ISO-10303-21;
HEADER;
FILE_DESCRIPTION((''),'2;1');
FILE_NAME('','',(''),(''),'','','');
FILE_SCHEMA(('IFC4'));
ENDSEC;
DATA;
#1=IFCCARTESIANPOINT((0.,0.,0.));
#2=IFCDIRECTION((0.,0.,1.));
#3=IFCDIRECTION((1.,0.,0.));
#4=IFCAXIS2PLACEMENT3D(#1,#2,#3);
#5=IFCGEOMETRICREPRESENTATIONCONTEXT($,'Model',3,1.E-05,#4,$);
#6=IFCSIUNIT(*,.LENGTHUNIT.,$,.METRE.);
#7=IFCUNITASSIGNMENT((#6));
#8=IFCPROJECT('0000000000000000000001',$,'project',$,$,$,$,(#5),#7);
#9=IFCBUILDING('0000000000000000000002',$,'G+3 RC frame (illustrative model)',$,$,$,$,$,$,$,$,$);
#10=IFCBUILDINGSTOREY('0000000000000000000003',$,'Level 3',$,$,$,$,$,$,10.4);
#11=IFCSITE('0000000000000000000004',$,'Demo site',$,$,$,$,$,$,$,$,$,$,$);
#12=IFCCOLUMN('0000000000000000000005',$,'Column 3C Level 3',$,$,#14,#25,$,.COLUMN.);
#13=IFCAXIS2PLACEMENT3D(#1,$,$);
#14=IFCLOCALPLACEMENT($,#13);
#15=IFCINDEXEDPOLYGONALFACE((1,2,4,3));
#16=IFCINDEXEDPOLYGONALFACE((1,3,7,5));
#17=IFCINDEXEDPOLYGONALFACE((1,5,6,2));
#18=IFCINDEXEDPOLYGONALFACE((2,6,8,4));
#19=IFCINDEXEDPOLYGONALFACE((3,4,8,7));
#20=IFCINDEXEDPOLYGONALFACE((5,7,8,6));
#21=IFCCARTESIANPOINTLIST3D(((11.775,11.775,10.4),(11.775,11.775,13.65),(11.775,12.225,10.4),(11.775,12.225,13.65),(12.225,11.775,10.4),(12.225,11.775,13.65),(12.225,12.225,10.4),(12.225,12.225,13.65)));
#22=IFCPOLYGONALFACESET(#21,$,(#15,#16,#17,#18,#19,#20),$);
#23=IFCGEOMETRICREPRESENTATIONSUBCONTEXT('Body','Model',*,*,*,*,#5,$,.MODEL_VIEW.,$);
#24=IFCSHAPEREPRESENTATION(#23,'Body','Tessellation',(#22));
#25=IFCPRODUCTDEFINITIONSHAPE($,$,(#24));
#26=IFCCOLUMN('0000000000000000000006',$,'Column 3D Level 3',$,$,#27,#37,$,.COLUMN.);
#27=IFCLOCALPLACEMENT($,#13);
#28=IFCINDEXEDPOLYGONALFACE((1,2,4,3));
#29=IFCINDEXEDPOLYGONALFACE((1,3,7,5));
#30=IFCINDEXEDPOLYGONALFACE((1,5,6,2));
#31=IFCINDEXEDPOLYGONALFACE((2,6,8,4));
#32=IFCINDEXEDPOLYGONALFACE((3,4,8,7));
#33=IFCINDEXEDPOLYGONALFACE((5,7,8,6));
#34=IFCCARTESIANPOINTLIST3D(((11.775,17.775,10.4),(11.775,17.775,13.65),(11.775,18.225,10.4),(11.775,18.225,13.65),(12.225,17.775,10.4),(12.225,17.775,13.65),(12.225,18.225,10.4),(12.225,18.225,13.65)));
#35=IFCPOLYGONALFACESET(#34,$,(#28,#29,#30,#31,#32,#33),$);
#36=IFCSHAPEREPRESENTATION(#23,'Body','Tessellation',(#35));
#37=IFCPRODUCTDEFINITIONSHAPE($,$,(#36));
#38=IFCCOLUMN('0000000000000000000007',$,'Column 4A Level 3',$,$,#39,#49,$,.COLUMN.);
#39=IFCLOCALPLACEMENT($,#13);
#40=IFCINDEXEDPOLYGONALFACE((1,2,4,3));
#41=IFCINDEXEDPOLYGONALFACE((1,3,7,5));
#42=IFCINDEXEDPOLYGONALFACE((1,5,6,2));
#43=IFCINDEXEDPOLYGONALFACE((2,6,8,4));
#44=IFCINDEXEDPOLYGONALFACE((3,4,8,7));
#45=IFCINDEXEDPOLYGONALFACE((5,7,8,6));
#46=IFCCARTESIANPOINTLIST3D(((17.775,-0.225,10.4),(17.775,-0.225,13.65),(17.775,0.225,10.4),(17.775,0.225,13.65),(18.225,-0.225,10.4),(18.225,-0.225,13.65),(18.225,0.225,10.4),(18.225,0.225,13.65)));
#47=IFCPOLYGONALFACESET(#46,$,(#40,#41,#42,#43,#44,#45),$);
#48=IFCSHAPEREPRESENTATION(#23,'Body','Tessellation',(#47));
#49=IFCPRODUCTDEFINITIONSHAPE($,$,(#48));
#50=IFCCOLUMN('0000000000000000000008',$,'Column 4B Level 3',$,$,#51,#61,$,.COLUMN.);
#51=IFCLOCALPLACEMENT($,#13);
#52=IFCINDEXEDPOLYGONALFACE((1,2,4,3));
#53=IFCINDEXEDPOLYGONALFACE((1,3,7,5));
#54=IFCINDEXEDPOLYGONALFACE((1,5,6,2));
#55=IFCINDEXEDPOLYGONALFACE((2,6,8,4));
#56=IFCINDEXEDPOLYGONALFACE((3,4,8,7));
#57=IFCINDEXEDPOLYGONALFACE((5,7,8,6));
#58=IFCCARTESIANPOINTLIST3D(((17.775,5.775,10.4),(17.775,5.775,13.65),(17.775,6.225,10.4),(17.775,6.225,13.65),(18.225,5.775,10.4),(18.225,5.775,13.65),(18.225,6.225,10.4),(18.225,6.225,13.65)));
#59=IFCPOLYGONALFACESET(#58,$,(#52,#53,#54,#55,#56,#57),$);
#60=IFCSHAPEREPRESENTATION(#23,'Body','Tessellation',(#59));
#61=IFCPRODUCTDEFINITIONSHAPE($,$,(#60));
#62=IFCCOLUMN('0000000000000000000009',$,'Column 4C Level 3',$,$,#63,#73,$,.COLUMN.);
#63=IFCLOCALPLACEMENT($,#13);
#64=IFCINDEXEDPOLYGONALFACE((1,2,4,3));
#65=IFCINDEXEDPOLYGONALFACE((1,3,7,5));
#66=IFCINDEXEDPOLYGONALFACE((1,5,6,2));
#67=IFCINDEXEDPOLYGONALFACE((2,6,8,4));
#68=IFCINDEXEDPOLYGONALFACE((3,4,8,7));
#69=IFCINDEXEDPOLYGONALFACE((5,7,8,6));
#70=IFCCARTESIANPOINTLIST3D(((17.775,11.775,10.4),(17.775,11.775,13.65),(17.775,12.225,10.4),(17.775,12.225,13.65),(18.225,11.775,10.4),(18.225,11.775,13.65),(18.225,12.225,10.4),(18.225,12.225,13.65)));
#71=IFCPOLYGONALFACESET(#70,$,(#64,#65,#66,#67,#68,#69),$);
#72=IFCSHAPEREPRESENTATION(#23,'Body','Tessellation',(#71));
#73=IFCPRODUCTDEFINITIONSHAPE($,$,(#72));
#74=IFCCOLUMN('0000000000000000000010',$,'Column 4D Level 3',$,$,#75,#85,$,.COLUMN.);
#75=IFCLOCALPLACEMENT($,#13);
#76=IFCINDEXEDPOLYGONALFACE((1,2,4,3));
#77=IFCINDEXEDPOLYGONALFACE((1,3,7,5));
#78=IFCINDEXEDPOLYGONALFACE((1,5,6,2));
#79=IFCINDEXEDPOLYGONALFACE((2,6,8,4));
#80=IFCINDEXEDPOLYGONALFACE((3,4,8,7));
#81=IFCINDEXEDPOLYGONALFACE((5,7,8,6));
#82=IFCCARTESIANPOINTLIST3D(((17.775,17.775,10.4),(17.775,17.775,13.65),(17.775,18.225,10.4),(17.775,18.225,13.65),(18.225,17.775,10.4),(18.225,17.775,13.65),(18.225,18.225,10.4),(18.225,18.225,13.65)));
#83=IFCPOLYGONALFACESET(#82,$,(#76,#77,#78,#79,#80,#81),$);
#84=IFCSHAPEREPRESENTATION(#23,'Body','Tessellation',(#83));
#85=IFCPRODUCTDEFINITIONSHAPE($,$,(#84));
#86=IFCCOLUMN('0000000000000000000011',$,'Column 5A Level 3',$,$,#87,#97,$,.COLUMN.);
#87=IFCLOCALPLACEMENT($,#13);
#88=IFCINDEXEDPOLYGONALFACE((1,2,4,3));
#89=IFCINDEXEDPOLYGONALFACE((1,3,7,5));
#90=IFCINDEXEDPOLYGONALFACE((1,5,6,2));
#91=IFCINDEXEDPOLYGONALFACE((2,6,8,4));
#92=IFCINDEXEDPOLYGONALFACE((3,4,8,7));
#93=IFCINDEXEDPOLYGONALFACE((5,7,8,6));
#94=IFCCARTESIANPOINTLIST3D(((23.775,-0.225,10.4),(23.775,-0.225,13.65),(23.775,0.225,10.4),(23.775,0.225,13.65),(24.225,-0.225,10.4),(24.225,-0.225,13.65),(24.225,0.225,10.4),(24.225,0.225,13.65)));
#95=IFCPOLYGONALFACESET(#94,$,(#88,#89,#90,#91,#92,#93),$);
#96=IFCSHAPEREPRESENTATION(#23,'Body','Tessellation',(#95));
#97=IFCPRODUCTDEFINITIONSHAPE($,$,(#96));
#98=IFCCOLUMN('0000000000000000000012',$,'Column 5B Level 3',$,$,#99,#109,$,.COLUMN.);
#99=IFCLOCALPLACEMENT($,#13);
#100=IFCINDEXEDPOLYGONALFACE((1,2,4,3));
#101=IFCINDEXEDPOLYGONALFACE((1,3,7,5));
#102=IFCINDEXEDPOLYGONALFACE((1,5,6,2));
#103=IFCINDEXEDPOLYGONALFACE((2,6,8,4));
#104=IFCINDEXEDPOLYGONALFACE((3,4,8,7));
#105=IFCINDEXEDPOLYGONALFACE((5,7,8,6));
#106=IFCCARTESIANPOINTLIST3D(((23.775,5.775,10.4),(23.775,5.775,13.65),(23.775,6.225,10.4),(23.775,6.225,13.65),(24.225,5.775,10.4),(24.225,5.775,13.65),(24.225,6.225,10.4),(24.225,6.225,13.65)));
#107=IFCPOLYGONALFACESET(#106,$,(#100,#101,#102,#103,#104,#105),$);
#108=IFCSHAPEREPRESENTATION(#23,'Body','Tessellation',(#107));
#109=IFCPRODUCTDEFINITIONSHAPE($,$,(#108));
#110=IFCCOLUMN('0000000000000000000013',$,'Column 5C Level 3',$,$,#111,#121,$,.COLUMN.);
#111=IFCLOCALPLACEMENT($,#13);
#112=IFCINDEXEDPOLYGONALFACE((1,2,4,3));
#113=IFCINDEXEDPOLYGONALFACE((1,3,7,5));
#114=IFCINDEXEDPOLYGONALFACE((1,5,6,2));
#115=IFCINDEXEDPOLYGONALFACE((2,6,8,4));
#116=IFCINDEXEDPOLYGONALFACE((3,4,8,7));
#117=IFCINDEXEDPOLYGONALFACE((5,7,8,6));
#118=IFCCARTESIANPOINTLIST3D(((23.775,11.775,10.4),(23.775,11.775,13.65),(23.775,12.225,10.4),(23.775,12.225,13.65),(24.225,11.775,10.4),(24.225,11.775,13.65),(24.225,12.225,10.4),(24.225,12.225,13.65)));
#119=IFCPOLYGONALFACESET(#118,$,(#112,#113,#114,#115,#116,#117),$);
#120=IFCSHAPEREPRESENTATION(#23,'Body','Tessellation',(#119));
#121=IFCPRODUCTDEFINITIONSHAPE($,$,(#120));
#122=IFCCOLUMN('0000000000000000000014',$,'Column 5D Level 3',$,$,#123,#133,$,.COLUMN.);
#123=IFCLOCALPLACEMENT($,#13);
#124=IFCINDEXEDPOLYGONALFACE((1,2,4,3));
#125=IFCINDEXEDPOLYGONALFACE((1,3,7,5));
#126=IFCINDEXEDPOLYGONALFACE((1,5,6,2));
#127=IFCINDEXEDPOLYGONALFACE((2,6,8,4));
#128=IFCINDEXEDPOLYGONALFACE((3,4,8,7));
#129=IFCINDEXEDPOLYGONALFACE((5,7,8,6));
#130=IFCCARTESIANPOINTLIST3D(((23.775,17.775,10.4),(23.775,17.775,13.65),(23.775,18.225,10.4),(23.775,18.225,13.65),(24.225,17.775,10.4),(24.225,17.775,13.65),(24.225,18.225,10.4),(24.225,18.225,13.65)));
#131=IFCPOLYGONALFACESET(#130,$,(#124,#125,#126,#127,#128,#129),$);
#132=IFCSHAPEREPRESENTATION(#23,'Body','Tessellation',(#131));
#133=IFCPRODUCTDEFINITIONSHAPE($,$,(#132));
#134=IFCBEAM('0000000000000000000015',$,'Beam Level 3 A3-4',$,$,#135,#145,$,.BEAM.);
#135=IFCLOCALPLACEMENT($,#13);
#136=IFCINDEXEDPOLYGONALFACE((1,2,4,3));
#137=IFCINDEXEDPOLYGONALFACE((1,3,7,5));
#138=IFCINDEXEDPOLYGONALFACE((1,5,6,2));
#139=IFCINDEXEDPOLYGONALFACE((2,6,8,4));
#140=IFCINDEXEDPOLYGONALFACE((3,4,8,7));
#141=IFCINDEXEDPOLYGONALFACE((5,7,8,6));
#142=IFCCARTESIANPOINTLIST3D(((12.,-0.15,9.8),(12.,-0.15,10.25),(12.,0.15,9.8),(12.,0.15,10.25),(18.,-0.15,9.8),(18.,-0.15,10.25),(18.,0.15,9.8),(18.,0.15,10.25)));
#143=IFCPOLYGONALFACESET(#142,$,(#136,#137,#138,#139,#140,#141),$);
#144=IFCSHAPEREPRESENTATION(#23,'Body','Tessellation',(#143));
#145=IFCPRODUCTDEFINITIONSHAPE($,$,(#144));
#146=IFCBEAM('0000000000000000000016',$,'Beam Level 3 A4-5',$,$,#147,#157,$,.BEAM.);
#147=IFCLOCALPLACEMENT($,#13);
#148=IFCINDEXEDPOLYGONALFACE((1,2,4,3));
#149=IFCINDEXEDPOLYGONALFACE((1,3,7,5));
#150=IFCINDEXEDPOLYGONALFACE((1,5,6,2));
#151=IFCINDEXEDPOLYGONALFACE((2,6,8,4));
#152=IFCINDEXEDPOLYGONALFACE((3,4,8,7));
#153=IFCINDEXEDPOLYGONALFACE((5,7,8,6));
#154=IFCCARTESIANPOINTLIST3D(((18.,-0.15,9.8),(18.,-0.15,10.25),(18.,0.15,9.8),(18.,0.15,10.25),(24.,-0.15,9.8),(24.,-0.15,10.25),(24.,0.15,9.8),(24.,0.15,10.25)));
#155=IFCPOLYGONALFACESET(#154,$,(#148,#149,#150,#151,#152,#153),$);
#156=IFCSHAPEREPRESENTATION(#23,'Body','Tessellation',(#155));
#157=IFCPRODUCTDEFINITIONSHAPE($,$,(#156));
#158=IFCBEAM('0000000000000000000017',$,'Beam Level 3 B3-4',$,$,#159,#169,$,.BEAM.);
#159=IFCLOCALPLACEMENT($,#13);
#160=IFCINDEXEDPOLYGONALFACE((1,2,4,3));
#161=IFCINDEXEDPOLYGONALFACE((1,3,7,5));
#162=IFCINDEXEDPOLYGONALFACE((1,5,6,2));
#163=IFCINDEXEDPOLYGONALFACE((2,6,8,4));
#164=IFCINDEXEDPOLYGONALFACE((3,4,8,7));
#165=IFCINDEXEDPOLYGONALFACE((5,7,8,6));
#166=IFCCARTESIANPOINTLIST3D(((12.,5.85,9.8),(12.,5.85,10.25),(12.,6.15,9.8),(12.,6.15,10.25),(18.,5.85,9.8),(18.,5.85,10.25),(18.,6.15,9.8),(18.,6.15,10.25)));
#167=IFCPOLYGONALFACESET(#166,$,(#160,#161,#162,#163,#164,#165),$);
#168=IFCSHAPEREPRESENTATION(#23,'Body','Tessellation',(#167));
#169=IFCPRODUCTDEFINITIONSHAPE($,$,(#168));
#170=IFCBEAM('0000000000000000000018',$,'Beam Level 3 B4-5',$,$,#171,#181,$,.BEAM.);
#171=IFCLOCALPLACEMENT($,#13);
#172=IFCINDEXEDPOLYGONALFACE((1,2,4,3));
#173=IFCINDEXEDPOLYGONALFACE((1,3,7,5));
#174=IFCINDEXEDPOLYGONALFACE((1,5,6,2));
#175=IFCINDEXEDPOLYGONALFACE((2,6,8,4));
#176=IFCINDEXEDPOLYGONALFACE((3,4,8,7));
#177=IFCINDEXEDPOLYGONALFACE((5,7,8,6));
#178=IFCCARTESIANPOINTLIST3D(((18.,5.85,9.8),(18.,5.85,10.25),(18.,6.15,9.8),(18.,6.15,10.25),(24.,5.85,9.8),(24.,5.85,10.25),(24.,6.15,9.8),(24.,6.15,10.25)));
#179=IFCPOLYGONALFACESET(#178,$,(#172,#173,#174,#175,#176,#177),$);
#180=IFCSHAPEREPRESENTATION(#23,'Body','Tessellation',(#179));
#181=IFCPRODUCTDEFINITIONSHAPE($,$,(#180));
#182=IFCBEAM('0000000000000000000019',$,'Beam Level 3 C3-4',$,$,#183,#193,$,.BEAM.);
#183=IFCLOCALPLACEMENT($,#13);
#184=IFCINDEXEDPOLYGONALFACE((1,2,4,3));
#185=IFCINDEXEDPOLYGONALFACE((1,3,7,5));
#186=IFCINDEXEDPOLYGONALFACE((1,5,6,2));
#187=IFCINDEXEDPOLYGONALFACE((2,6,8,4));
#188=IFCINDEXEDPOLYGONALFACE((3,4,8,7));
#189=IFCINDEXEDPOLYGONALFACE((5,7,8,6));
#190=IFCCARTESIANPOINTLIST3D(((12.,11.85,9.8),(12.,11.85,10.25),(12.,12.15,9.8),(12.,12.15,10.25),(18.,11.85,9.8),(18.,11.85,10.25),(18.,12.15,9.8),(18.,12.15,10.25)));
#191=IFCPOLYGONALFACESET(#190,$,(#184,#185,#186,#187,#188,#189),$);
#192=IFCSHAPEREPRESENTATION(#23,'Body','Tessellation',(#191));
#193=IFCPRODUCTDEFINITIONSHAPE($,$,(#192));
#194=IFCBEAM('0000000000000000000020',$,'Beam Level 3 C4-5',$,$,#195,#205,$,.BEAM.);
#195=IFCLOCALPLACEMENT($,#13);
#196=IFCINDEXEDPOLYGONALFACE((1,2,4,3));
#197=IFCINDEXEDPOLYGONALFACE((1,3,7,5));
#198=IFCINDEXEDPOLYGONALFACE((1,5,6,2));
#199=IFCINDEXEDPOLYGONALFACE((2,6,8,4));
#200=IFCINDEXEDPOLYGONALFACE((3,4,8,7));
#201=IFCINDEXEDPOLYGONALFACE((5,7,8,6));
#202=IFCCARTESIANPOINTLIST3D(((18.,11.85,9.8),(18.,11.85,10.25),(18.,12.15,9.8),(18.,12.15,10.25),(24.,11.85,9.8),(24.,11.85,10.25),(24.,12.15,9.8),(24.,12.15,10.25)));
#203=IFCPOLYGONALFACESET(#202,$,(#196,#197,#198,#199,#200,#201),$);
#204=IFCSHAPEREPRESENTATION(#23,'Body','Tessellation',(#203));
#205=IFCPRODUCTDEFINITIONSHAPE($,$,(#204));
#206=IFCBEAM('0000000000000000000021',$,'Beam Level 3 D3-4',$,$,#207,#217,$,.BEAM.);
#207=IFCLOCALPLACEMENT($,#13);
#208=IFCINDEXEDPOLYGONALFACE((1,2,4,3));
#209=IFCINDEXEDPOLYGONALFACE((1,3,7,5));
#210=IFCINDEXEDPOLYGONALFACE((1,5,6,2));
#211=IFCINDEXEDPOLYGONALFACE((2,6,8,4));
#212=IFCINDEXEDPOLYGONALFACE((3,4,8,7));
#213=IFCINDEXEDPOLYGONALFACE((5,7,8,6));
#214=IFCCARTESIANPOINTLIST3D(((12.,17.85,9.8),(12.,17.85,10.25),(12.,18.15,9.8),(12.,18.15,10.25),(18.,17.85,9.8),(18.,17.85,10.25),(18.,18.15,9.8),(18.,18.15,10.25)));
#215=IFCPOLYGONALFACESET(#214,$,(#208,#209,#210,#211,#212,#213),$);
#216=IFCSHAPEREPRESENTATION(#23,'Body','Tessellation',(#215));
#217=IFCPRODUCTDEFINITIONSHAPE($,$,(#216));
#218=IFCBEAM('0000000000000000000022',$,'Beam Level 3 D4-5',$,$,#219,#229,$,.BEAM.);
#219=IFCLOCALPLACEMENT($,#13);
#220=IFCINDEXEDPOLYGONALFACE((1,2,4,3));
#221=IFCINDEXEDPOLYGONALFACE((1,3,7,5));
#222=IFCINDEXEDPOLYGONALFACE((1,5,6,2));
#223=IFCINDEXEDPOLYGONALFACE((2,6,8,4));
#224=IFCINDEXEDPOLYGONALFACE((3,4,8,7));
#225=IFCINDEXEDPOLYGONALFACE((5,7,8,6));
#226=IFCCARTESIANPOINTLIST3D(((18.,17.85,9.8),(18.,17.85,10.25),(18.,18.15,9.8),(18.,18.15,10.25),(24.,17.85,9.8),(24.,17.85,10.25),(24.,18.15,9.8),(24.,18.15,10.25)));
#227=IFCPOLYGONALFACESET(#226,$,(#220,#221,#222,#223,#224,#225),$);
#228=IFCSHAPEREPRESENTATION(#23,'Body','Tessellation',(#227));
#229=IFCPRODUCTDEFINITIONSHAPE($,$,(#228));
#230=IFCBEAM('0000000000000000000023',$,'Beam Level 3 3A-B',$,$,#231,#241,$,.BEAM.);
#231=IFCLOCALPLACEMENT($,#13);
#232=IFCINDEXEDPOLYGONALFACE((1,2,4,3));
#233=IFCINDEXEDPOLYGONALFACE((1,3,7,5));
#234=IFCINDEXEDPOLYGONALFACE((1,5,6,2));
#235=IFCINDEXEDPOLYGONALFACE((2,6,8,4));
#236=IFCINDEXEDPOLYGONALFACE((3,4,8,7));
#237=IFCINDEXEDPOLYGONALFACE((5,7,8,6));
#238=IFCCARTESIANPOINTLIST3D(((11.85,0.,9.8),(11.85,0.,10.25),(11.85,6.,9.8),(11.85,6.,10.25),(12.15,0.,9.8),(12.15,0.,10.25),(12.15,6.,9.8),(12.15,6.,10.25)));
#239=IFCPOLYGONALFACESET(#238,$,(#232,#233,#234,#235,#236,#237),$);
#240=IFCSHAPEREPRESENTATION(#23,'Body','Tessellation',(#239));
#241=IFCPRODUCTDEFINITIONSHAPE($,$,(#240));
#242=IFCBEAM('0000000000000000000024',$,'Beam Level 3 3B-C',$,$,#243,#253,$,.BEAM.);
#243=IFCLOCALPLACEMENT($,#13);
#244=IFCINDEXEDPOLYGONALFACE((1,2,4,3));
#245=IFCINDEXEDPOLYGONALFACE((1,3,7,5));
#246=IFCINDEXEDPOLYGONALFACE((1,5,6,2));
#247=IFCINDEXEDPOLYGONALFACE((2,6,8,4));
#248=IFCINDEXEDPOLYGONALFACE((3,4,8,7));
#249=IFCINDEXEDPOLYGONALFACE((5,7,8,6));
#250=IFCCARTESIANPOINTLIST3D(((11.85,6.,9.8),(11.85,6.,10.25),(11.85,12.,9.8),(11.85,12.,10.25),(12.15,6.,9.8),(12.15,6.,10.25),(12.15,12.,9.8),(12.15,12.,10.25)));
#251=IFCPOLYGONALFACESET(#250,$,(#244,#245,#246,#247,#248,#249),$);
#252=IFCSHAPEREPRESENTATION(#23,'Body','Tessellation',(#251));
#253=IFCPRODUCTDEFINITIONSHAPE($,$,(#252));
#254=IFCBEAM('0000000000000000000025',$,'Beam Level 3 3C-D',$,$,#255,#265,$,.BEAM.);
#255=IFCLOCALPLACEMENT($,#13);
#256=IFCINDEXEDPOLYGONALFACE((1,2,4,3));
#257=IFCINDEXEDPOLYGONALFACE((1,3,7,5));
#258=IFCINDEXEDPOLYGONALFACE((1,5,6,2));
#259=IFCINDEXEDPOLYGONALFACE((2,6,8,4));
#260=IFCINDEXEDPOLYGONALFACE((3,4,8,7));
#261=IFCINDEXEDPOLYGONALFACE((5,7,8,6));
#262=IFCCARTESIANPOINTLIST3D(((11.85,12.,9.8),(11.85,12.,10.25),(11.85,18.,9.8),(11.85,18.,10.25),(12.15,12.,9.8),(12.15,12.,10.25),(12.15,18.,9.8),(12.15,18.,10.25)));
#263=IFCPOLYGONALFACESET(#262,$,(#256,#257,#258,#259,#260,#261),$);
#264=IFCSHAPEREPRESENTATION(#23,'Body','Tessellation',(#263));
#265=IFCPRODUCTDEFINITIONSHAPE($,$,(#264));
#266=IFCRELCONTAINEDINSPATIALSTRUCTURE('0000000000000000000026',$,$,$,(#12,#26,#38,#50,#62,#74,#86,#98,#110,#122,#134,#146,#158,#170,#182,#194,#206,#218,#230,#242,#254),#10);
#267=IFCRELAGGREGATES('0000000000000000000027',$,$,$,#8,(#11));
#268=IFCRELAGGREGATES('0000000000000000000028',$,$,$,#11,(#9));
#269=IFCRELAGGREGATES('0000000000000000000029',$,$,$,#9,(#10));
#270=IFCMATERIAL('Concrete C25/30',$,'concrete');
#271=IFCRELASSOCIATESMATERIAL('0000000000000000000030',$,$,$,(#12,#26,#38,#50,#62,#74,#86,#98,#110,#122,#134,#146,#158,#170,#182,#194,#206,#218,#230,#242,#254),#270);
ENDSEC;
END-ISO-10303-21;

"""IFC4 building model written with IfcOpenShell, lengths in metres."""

from ifc_helpers import new_model, si_unit, frame, frame_2d, origin, origin_with_axes, place, context, subcontext, project, spatial, rectangle, extrude, material, element, save


model = new_model("IFC4")

# Units and contexts
model_context = context("Model", 3, precision=1e-05, world=origin_with_axes())
body_context = subcontext(model_context, "Body", "Model", "MODEL_VIEW")
ifc_project = project(units=[si_unit("LENGTHUNIT", "METRE")], contexts=[model_context])

# Site, building, storey
site = spatial("IfcSite", under=ifc_project, Name="Demo site")
building = spatial("IfcBuilding", under=site, Name="G+3 RC frame (illustrative model)")
storey = spatial("IfcBuildingStorey", under=building, Name="Level 3", Elevation=10.4)

# Columns
ifc_material_1 = material(Name="Concrete C25/30", Category="concrete")
for number, where, z_axis, x_axis, name in (
    (1, (11.775, 11.775, 10.4), (0.0, 0.0, 1.0), (1.0, 0.0, 0.0), "Column 3C Level 3"),
    (2, (11.775, 17.775, 10.4), (0.0, 0.0, 1.0), (1.0, 0.0, 0.0), "Column 3D Level 3"),
    (3, (17.775, -0.225, 10.4), (0.0, 0.0, 1.0), (1.0, 0.0, 0.0), "Column 4A Level 3"),
    (4, (17.775, 5.775, 10.4), (0.0, 0.0, 1.0), (1.0, 0.0, 0.0), "Column 4B Level 3"),
    (5, (17.775, 11.775, 10.4), (0.0, 0.0, 1.0), (1.0, 0.0, 0.0), "Column 4C Level 3"),
    (6, (17.775, 17.775, 10.4), (0.0, 0.0, 1.0), (1.0, 0.0, 0.0), "Column 4D Level 3"),
    (7, (23.775, -0.225, 10.4), (0.0, 0.0, 1.0), (1.0, 0.0, 0.0), "Column 5A Level 3"),
    (8, (23.775, 5.775, 10.4), (0.0, 0.0, 1.0), (1.0, 0.0, 0.0), "Column 5B Level 3"),
    (9, (23.775, 11.775, 10.4), (0.0, 0.0, 1.0), (1.0, 0.0, 0.0), "Column 5C Level 3"),
    (10, (23.775, 17.775, 10.4), (0.0, 0.0, 1.0), (1.0, 0.0, 0.0), "Column 5D Level 3"),
):
    element("IfcColumn", number, at=place(None, frame(where, z_axis=z_axis, x_axis=x_axis)), inside=storey, material=ifc_material_1, Name=name, PredefinedType="COLUMN", context=body_context, shape_type="SweptSolid", body=[
        extrude(rectangle(XDim=0.45, YDim=0.45, at=frame_2d((0.225, 0.225))), origin(), (0.0, 0.0, 1.0), 3.25),
    ])

# Beams
for number, where, z_axis, x_axis, name in (
    (11, (12.0, -0.15, 9.8), (0.0, 0.0, 1.0), (1.0, 0.0, 0.0), "Beam Level 3 A3-4"),
    (12, (18.0, -0.15, 9.8), (0.0, 0.0, 1.0), (1.0, 0.0, 0.0), "Beam Level 3 A4-5"),
    (13, (12.0, 5.85, 9.8), (0.0, 0.0, 1.0), (1.0, 0.0, 0.0), "Beam Level 3 B3-4"),
    (14, (18.0, 5.85, 9.8), (0.0, 0.0, 1.0), (1.0, 0.0, 0.0), "Beam Level 3 B4-5"),
    (15, (12.0, 11.85, 9.8), (0.0, 0.0, 1.0), (1.0, 0.0, 0.0), "Beam Level 3 C3-4"),
    (16, (18.0, 11.85, 9.8), (0.0, 0.0, 1.0), (1.0, 0.0, 0.0), "Beam Level 3 C4-5"),
    (17, (12.0, 17.85, 9.8), (0.0, 0.0, 1.0), (1.0, 0.0, 0.0), "Beam Level 3 D3-4"),
    (18, (18.0, 17.85, 9.8), (0.0, 0.0, 1.0), (1.0, 0.0, 0.0), "Beam Level 3 D4-5"),
):
    element("IfcBeam", number, at=place(None, frame(where, z_axis=z_axis, x_axis=x_axis)), inside=storey, material=ifc_material_1, Name=name, PredefinedType="BEAM", context=body_context, shape_type="SweptSolid", body=[
        extrude(rectangle(XDim=6.0, YDim=0.3, at=frame_2d((3.0, 0.15))), origin(), (0.0, 0.0, 1.0), 0.45),
    ])
for number, where, z_axis, x_axis, name in (
    (19, (11.85, 0.0, 9.8), (0.0, 0.0, 1.0), (1.0, 0.0, 0.0), "Beam Level 3 3A-B"),
    (20, (11.85, 6.0, 9.8), (0.0, 0.0, 1.0), (1.0, 0.0, 0.0), "Beam Level 3 3B-C"),
    (21, (11.85, 12.0, 9.8), (0.0, 0.0, 1.0), (1.0, 0.0, 0.0), "Beam Level 3 3C-D"),
):
    element("IfcBeam", number, at=place(None, frame(where, z_axis=z_axis, x_axis=x_axis)), inside=storey, material=ifc_material_1, Name=name, PredefinedType="BEAM", context=body_context, shape_type="SweptSolid", body=[
        extrude(rectangle(XDim=0.3, YDim=6.0, at=frame_2d((0.15, 3.0))), origin(), (0.0, 0.0, 1.0), 0.45),
    ])

save(model, "model.ifc")
